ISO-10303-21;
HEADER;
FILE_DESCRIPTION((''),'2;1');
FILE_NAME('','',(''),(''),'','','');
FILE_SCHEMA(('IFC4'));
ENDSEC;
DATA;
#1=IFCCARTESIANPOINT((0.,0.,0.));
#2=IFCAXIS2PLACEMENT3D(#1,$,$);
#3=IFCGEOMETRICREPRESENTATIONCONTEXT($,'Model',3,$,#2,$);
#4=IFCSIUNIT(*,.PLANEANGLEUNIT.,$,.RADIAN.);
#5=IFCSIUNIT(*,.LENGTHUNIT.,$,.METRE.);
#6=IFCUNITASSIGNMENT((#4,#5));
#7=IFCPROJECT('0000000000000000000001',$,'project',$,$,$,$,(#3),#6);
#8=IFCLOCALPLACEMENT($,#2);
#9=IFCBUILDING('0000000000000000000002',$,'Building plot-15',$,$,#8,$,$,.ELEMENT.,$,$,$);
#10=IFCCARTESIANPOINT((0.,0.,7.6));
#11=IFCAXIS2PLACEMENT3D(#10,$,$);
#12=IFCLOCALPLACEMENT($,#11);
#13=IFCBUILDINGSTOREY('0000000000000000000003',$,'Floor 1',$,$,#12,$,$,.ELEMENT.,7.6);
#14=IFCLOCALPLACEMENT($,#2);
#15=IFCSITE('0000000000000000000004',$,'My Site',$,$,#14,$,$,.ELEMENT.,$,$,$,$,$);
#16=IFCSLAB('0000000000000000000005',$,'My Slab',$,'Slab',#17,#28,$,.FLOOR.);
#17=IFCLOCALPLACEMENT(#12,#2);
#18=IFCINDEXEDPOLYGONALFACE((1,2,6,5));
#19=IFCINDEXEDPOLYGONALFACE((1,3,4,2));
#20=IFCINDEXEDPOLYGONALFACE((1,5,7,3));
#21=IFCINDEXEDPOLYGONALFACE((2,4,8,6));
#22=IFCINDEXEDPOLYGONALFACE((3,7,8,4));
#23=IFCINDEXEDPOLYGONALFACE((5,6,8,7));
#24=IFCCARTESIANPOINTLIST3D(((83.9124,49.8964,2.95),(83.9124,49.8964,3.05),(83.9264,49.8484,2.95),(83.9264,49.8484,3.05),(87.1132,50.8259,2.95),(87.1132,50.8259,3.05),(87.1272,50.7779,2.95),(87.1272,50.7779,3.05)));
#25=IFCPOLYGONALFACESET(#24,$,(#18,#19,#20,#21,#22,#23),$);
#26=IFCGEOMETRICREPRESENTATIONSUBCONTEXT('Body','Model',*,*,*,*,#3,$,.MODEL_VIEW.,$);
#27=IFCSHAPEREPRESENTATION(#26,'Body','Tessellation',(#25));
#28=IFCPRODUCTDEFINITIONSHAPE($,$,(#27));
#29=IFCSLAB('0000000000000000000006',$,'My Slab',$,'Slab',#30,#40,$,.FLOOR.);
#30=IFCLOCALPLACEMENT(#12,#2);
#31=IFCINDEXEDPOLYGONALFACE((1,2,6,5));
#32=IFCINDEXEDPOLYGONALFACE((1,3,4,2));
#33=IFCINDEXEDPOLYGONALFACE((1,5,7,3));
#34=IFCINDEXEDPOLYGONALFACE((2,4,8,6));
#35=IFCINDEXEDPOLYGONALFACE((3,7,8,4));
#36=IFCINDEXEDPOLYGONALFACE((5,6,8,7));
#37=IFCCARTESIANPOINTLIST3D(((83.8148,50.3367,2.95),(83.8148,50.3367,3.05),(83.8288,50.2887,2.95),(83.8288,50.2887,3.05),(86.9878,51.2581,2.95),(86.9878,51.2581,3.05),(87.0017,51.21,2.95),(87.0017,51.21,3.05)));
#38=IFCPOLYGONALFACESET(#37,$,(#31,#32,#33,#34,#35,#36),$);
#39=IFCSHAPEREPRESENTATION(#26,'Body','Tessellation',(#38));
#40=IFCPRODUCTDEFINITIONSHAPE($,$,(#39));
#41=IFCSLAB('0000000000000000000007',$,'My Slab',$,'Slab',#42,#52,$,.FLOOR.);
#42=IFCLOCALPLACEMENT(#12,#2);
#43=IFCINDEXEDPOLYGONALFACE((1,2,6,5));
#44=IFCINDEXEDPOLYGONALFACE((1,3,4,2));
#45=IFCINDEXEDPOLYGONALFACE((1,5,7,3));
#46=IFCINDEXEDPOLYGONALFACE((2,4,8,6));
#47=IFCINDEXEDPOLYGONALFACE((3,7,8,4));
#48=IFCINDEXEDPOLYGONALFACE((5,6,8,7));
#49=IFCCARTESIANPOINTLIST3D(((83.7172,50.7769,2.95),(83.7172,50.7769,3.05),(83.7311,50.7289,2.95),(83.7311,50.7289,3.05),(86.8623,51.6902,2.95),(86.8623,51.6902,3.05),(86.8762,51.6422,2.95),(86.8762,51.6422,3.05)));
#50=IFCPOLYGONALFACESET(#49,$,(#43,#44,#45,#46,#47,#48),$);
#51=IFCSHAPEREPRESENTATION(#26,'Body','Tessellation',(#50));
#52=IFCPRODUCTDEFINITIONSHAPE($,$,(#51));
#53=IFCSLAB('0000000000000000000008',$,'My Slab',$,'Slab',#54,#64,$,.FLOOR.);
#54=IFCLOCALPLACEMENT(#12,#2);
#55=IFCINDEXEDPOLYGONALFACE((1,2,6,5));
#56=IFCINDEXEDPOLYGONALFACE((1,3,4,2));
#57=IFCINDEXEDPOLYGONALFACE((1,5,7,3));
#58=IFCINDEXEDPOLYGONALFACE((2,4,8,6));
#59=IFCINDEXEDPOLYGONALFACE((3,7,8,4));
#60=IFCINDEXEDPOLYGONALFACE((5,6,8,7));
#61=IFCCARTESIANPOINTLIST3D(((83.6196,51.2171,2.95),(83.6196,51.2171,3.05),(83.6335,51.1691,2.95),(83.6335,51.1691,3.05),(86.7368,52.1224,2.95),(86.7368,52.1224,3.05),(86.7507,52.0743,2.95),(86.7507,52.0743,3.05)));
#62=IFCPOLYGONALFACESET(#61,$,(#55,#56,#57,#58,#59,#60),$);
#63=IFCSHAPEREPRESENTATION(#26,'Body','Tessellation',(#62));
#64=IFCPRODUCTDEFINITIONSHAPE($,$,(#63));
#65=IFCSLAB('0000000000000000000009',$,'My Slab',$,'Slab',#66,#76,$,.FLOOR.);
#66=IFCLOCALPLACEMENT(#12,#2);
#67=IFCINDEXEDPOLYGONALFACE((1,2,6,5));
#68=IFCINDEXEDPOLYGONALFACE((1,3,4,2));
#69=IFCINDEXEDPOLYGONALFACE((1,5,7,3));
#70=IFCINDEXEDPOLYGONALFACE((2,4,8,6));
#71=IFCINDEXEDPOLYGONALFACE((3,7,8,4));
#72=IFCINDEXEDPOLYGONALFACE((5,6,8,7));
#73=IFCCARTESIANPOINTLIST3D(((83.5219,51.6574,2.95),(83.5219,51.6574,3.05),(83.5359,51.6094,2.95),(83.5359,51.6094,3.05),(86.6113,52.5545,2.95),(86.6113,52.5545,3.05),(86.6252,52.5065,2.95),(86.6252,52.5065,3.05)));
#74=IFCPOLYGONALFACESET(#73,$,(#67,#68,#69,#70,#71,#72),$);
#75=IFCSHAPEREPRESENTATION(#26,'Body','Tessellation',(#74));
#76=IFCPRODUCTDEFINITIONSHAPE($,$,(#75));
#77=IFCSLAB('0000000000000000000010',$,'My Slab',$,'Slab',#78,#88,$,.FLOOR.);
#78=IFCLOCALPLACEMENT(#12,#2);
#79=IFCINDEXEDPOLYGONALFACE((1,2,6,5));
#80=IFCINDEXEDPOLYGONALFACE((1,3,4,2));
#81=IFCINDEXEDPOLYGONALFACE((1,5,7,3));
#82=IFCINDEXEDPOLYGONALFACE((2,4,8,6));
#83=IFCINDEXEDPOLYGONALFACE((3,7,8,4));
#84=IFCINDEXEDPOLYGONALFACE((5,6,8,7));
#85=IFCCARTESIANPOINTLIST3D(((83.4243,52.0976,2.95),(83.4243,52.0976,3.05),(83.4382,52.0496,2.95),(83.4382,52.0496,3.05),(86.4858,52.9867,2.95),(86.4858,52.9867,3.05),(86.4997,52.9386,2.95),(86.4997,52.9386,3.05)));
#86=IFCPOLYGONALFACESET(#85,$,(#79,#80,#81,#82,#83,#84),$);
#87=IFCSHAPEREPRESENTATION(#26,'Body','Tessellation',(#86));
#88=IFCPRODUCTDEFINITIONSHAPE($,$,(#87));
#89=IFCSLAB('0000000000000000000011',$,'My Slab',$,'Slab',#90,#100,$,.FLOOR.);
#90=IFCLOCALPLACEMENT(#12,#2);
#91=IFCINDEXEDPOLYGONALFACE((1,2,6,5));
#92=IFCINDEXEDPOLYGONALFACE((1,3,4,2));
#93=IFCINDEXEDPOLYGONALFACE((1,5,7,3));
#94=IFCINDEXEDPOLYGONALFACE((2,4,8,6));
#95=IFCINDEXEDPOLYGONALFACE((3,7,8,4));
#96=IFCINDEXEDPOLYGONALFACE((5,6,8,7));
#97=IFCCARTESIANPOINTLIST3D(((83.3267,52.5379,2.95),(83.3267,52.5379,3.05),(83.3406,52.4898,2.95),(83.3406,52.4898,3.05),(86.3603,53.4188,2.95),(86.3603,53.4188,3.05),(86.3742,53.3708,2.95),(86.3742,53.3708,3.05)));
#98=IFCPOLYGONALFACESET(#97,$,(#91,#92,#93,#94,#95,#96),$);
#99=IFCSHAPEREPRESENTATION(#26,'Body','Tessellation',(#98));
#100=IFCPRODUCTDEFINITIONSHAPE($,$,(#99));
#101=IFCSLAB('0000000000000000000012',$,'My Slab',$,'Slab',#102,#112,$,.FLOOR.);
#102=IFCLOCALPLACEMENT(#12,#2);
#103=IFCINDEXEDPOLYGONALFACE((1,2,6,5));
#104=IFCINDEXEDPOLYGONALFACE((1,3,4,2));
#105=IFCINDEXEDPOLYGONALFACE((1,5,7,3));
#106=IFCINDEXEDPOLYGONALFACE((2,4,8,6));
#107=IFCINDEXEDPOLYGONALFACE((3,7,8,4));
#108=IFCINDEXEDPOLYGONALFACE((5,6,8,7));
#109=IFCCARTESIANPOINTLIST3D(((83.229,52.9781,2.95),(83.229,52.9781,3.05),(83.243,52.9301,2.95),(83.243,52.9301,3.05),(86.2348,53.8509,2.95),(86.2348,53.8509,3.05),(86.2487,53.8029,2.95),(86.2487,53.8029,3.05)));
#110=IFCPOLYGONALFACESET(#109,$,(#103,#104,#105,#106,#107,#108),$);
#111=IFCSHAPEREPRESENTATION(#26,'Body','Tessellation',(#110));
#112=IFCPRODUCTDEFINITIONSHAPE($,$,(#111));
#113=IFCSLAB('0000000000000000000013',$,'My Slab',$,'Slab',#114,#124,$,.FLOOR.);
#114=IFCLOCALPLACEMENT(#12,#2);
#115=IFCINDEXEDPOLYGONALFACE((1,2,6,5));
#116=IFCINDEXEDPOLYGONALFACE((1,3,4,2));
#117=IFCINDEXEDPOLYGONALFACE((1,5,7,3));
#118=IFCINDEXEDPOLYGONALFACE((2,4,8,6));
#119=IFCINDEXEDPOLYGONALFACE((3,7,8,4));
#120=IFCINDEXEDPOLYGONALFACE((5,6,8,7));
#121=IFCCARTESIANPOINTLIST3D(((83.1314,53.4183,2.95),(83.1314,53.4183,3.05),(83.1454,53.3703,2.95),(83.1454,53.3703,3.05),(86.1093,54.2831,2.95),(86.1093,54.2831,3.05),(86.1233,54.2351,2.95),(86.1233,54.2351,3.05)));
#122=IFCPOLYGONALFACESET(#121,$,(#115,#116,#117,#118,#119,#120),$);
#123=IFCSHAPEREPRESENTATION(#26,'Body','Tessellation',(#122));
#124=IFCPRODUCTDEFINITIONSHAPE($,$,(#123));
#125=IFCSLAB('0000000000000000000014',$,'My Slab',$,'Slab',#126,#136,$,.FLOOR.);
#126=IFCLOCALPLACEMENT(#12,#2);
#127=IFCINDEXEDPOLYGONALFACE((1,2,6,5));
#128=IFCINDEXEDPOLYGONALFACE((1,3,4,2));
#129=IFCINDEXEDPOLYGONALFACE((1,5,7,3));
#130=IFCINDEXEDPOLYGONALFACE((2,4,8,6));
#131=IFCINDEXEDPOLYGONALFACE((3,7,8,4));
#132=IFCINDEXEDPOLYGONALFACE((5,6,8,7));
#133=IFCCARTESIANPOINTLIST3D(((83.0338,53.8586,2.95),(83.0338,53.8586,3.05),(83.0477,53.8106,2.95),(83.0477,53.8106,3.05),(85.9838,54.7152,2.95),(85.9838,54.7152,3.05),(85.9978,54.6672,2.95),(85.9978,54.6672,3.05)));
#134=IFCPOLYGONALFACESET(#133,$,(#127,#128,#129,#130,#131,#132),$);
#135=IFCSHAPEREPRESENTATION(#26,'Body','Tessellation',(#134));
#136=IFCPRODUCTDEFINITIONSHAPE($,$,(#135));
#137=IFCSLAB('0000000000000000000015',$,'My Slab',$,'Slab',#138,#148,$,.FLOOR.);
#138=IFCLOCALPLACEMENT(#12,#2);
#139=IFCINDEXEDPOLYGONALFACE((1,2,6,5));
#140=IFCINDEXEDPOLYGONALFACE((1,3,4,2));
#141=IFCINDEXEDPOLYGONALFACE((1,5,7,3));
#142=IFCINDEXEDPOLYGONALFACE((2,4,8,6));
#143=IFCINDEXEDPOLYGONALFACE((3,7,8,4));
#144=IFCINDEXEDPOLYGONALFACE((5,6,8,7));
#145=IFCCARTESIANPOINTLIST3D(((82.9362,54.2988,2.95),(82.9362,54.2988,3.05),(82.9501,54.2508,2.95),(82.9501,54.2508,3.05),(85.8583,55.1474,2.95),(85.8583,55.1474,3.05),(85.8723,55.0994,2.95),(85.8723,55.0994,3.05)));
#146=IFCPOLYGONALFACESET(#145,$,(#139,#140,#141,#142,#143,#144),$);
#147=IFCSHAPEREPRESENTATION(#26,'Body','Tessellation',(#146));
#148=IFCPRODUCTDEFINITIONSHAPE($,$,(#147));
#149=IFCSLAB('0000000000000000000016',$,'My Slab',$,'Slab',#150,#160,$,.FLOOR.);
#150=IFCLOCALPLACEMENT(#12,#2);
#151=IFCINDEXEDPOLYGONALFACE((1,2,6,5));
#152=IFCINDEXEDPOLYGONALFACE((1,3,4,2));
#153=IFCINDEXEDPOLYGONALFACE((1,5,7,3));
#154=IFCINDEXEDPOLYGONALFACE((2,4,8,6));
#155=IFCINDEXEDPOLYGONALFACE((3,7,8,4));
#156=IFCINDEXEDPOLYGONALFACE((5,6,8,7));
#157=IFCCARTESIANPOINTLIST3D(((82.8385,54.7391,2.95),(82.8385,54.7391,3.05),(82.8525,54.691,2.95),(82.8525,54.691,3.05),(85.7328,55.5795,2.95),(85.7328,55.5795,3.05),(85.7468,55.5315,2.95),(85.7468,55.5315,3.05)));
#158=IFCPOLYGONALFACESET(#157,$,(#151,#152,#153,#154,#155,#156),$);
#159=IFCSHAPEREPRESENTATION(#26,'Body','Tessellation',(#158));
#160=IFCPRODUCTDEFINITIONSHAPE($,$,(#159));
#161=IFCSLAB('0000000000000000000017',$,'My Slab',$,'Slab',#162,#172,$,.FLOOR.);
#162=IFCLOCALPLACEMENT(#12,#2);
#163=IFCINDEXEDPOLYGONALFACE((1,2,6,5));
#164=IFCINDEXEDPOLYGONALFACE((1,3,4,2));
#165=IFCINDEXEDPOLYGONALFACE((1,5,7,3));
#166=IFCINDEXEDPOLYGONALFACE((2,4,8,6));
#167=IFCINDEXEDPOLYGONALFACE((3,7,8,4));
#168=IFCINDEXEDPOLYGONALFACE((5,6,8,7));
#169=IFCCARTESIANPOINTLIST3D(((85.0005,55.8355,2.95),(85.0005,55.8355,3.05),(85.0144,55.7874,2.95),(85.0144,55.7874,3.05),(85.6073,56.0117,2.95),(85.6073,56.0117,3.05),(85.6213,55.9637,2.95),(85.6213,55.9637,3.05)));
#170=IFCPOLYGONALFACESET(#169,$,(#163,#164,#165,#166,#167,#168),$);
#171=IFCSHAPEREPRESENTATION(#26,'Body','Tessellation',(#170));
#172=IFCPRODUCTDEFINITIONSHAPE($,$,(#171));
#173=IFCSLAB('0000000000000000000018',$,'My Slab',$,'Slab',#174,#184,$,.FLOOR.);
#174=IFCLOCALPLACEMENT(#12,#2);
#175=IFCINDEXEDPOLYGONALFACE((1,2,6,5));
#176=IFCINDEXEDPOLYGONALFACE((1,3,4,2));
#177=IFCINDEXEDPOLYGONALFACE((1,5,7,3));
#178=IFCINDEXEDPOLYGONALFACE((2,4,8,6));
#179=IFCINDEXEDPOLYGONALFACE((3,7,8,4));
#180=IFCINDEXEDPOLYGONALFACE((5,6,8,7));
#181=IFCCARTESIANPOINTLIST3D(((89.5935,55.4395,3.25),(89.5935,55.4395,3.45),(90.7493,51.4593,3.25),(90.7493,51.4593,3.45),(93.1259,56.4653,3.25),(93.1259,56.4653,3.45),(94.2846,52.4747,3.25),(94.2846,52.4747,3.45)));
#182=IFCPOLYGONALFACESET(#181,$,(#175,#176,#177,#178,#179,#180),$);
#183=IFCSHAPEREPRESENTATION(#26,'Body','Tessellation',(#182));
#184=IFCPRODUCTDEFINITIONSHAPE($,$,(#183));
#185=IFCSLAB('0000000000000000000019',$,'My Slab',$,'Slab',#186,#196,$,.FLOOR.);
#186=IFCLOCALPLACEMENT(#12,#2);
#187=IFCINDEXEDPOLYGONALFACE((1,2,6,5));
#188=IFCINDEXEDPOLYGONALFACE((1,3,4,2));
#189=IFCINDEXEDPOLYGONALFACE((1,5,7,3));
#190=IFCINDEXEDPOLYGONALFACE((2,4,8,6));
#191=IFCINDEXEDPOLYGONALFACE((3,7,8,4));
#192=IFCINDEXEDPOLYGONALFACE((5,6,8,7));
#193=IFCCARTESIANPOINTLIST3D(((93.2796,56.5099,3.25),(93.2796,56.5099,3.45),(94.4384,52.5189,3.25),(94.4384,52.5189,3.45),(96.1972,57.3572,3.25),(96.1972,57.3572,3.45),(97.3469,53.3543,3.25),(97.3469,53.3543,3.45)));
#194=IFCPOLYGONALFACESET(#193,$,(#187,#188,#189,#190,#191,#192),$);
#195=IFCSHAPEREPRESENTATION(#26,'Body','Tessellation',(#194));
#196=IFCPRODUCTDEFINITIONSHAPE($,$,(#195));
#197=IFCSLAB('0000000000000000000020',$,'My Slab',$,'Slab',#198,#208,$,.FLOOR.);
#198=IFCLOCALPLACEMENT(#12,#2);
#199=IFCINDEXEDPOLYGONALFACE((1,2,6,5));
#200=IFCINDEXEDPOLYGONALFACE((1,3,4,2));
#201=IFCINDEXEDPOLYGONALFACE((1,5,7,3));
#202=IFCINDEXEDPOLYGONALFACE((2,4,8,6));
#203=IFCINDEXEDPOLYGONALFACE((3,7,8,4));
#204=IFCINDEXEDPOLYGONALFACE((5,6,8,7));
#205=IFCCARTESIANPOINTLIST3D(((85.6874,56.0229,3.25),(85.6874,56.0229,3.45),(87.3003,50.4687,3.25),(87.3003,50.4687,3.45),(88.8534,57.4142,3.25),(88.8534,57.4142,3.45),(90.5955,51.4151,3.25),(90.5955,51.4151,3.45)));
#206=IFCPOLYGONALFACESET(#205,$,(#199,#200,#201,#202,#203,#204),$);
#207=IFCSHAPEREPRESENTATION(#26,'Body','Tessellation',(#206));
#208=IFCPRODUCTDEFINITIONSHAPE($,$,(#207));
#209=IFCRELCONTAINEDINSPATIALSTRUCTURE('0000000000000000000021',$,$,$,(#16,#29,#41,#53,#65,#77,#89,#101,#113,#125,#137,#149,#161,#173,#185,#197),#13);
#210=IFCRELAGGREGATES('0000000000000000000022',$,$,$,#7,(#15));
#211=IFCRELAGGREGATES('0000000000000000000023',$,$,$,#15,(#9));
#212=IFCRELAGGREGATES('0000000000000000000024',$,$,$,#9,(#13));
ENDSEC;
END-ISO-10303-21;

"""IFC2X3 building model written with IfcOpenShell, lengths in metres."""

from ifc_helpers import new_model, si_unit, frame, origin, place, context, subcontext, project, spatial, polyline, outline, extrude, element, save


model = new_model("IFC2X3")

# Units and contexts
model_context = context("Model", 3, world=origin())
body_context = subcontext(model_context, "Body", "Model", "MODEL_VIEW")
ifc_project = project(units=[si_unit("PLANEANGLEUNIT", "RADIAN"), si_unit("LENGTHUNIT", "METRE")], contexts=[model_context])

# Site, building, storey
site_placement = place(None, origin())
site = spatial("IfcSite", under=ifc_project, at=site_placement, Name="My Site", CompositionType="ELEMENT")
building_placement = place(None, origin())
building = spatial("IfcBuilding", under=site, at=building_placement, Name="Building plot-15", CompositionType="ELEMENT")
storey_placement = place(None, frame((0.0, 0.0, 7.6)))
storey = spatial("IfcBuildingStorey", under=building, at=storey_placement, Name="Floor 1", CompositionType="ELEMENT", Elevation=7.6)

# Slabs
slab_1_placement = place(storey_placement, frame((0.0, 0.0, 2.95)))
element("IfcSlab", 1, at=slab_1_placement, inside=storey, Name="My Slab", ObjectType="Slab", PredefinedType="FLOOR", context=body_context, shape_type="SweptSolid", body=[
    extrude(outline(polyline([(87.1272, 50.7779), (87.1132, 50.8259), (83.9124, 49.8964), (83.9264, 49.8484), (87.1272, 50.7779)])), origin(), (0.0, 0.0, 1.0), 0.1),
])
slab_2_placement = place(storey_placement, frame((0.0, 0.0, 2.95)))
element("IfcSlab", 2, at=slab_2_placement, inside=storey, Name="My Slab", ObjectType="Slab", PredefinedType="FLOOR", context=body_context, shape_type="SweptSolid", body=[
    extrude(outline(polyline([(87.0017, 51.21), (86.9878, 51.2581), (83.8148, 50.3367), (83.8288, 50.2887), (87.0017, 51.21)])), origin(), (0.0, 0.0, 1.0), 0.1),
])
slab_3_placement = place(storey_placement, frame((0.0, 0.0, 2.95)))
element("IfcSlab", 3, at=slab_3_placement, inside=storey, Name="My Slab", ObjectType="Slab", PredefinedType="FLOOR", context=body_context, shape_type="SweptSolid", body=[
    extrude(outline(polyline([(86.8762, 51.6422), (86.8623, 51.6902), (83.7172, 50.7769), (83.7311, 50.7289), (86.8762, 51.6422)])), origin(), (0.0, 0.0, 1.0), 0.1),
])
slab_4_placement = place(storey_placement, frame((0.0, 0.0, 2.95)))
element("IfcSlab", 4, at=slab_4_placement, inside=storey, Name="My Slab", ObjectType="Slab", PredefinedType="FLOOR", context=body_context, shape_type="SweptSolid", body=[
    extrude(outline(polyline([(86.7507, 52.0743), (86.7368, 52.1224), (83.6196, 51.2171), (83.6335, 51.1691), (86.7507, 52.0743)])), origin(), (0.0, 0.0, 1.0), 0.1),
])
slab_5_placement = place(storey_placement, frame((0.0, 0.0, 2.95)))
element("IfcSlab", 5, at=slab_5_placement, inside=storey, Name="My Slab", ObjectType="Slab", PredefinedType="FLOOR", context=body_context, shape_type="SweptSolid", body=[
    extrude(outline(polyline([(86.6252, 52.5065), (86.6113, 52.5545), (83.5219, 51.6574), (83.5359, 51.6094), (86.6252, 52.5065)])), origin(), (0.0, 0.0, 1.0), 0.1),
])
slab_6_placement = place(storey_placement, frame((0.0, 0.0, 2.95)))
element("IfcSlab", 6, at=slab_6_placement, inside=storey, Name="My Slab", ObjectType="Slab", PredefinedType="FLOOR", context=body_context, shape_type="SweptSolid", body=[
    extrude(outline(polyline([(86.4997, 52.9386), (86.4858, 52.9867), (83.4243, 52.0976), (83.4382, 52.0496), (86.4997, 52.9386)])), origin(), (0.0, 0.0, 1.0), 0.1),
])
slab_7_placement = place(storey_placement, frame((0.0, 0.0, 2.95)))
element("IfcSlab", 7, at=slab_7_placement, inside=storey, Name="My Slab", ObjectType="Slab", PredefinedType="FLOOR", context=body_context, shape_type="SweptSolid", body=[
    extrude(outline(polyline([(86.3742, 53.3708), (86.3603, 53.4188), (83.3267, 52.5379), (83.3406, 52.4898), (86.3742, 53.3708)])), origin(), (0.0, 0.0, 1.0), 0.1),
])
slab_8_placement = place(storey_placement, frame((0.0, 0.0, 2.95)))
element("IfcSlab", 8, at=slab_8_placement, inside=storey, Name="My Slab", ObjectType="Slab", PredefinedType="FLOOR", context=body_context, shape_type="SweptSolid", body=[
    extrude(outline(polyline([(86.2487, 53.8029), (86.2348, 53.8509), (83.229, 52.9781), (83.243, 52.9301), (86.2487, 53.8029)])), origin(), (0.0, 0.0, 1.0), 0.1),
])
slab_9_placement = place(storey_placement, frame((0.0, 0.0, 2.95)))
element("IfcSlab", 9, at=slab_9_placement, inside=storey, Name="My Slab", ObjectType="Slab", PredefinedType="FLOOR", context=body_context, shape_type="SweptSolid", body=[
    extrude(outline(polyline([(86.1233, 54.2351), (86.1093, 54.2831), (83.1314, 53.4183), (83.1454, 53.3703), (86.1233, 54.2351)])), origin(), (0.0, 0.0, 1.0), 0.1),
])
slab_10_placement = place(storey_placement, frame((0.0, 0.0, 2.95)))
element("IfcSlab", 10, at=slab_10_placement, inside=storey, Name="My Slab", ObjectType="Slab", PredefinedType="FLOOR", context=body_context, shape_type="SweptSolid", body=[
    extrude(outline(polyline([(85.9978, 54.6672), (85.9838, 54.7152), (83.0338, 53.8586), (83.0477, 53.8106), (85.9978, 54.6672)])), origin(), (0.0, 0.0, 1.0), 0.1),
])
slab_11_placement = place(storey_placement, frame((0.0, 0.0, 2.95)))
element("IfcSlab", 11, at=slab_11_placement, inside=storey, Name="My Slab", ObjectType="Slab", PredefinedType="FLOOR", context=body_context, shape_type="SweptSolid", body=[
    extrude(outline(polyline([(85.8723, 55.0994), (85.8583, 55.1474), (82.9362, 54.2988), (82.9501, 54.2508), (85.8723, 55.0994)])), origin(), (0.0, 0.0, 1.0), 0.1),
])
slab_12_placement = place(storey_placement, frame((0.0, 0.0, 2.95)))
element("IfcSlab", 12, at=slab_12_placement, inside=storey, Name="My Slab", ObjectType="Slab", PredefinedType="FLOOR", context=body_context, shape_type="SweptSolid", body=[
    extrude(outline(polyline([(85.7468, 55.5315), (85.7328, 55.5795), (82.8385, 54.7391), (82.8525, 54.691), (85.7468, 55.5315)])), origin(), (0.0, 0.0, 1.0), 0.1),
])
slab_13_placement = place(storey_placement, frame((0.0, 0.0, 2.95)))
element("IfcSlab", 13, at=slab_13_placement, inside=storey, Name="My Slab", ObjectType="Slab", PredefinedType="FLOOR", context=body_context, shape_type="SweptSolid", body=[
    extrude(outline(polyline([(85.6213, 55.9637), (85.6073, 56.0117), (85.0005, 55.8355), (85.0144, 55.7874), (85.6213, 55.9637)])), origin(), (0.0, 0.0, 1.0), 0.1),
])
slab_14_placement = place(storey_placement, frame((0.0, 0.0, 3.25)))
element("IfcSlab", 14, at=slab_14_placement, inside=storey, Name="My Slab", ObjectType="Slab", PredefinedType="FLOOR", context=body_context, shape_type="SweptSolid", body=[
    extrude(outline(polyline([(93.1259, 56.4653), (89.5935, 55.4395), (90.7493, 51.4593), (94.2846, 52.4747), (93.1259, 56.4653)])), origin(), (0.0, 0.0, 1.0), 0.2),
])
slab_15_placement = place(storey_placement, frame((0.0, 0.0, 3.25)))
element("IfcSlab", 15, at=slab_15_placement, inside=storey, Name="My Slab", ObjectType="Slab", PredefinedType="FLOOR", context=body_context, shape_type="SweptSolid", body=[
    extrude(outline(polyline([(96.1972, 57.3572), (93.2796, 56.5099), (94.4384, 52.5189), (97.3469, 53.3543), (96.1972, 57.3572)])), origin(), (0.0, 0.0, 1.0), 0.2),
])
slab_16_placement = place(storey_placement, frame((0.0, 0.0, 3.25)))
element("IfcSlab", 16, at=slab_16_placement, inside=storey, Name="My Slab", ObjectType="Slab", PredefinedType="FLOOR", context=body_context, shape_type="SweptSolid", body=[
    extrude(outline(polyline([(87.3003, 50.4687), (90.5955, 51.4151), (88.8534, 57.4142), (85.6874, 56.0229), (87.3003, 50.4687)])), origin(), (0.0, 0.0, 1.0), 0.2),
])

save(model, "model.ifc")
